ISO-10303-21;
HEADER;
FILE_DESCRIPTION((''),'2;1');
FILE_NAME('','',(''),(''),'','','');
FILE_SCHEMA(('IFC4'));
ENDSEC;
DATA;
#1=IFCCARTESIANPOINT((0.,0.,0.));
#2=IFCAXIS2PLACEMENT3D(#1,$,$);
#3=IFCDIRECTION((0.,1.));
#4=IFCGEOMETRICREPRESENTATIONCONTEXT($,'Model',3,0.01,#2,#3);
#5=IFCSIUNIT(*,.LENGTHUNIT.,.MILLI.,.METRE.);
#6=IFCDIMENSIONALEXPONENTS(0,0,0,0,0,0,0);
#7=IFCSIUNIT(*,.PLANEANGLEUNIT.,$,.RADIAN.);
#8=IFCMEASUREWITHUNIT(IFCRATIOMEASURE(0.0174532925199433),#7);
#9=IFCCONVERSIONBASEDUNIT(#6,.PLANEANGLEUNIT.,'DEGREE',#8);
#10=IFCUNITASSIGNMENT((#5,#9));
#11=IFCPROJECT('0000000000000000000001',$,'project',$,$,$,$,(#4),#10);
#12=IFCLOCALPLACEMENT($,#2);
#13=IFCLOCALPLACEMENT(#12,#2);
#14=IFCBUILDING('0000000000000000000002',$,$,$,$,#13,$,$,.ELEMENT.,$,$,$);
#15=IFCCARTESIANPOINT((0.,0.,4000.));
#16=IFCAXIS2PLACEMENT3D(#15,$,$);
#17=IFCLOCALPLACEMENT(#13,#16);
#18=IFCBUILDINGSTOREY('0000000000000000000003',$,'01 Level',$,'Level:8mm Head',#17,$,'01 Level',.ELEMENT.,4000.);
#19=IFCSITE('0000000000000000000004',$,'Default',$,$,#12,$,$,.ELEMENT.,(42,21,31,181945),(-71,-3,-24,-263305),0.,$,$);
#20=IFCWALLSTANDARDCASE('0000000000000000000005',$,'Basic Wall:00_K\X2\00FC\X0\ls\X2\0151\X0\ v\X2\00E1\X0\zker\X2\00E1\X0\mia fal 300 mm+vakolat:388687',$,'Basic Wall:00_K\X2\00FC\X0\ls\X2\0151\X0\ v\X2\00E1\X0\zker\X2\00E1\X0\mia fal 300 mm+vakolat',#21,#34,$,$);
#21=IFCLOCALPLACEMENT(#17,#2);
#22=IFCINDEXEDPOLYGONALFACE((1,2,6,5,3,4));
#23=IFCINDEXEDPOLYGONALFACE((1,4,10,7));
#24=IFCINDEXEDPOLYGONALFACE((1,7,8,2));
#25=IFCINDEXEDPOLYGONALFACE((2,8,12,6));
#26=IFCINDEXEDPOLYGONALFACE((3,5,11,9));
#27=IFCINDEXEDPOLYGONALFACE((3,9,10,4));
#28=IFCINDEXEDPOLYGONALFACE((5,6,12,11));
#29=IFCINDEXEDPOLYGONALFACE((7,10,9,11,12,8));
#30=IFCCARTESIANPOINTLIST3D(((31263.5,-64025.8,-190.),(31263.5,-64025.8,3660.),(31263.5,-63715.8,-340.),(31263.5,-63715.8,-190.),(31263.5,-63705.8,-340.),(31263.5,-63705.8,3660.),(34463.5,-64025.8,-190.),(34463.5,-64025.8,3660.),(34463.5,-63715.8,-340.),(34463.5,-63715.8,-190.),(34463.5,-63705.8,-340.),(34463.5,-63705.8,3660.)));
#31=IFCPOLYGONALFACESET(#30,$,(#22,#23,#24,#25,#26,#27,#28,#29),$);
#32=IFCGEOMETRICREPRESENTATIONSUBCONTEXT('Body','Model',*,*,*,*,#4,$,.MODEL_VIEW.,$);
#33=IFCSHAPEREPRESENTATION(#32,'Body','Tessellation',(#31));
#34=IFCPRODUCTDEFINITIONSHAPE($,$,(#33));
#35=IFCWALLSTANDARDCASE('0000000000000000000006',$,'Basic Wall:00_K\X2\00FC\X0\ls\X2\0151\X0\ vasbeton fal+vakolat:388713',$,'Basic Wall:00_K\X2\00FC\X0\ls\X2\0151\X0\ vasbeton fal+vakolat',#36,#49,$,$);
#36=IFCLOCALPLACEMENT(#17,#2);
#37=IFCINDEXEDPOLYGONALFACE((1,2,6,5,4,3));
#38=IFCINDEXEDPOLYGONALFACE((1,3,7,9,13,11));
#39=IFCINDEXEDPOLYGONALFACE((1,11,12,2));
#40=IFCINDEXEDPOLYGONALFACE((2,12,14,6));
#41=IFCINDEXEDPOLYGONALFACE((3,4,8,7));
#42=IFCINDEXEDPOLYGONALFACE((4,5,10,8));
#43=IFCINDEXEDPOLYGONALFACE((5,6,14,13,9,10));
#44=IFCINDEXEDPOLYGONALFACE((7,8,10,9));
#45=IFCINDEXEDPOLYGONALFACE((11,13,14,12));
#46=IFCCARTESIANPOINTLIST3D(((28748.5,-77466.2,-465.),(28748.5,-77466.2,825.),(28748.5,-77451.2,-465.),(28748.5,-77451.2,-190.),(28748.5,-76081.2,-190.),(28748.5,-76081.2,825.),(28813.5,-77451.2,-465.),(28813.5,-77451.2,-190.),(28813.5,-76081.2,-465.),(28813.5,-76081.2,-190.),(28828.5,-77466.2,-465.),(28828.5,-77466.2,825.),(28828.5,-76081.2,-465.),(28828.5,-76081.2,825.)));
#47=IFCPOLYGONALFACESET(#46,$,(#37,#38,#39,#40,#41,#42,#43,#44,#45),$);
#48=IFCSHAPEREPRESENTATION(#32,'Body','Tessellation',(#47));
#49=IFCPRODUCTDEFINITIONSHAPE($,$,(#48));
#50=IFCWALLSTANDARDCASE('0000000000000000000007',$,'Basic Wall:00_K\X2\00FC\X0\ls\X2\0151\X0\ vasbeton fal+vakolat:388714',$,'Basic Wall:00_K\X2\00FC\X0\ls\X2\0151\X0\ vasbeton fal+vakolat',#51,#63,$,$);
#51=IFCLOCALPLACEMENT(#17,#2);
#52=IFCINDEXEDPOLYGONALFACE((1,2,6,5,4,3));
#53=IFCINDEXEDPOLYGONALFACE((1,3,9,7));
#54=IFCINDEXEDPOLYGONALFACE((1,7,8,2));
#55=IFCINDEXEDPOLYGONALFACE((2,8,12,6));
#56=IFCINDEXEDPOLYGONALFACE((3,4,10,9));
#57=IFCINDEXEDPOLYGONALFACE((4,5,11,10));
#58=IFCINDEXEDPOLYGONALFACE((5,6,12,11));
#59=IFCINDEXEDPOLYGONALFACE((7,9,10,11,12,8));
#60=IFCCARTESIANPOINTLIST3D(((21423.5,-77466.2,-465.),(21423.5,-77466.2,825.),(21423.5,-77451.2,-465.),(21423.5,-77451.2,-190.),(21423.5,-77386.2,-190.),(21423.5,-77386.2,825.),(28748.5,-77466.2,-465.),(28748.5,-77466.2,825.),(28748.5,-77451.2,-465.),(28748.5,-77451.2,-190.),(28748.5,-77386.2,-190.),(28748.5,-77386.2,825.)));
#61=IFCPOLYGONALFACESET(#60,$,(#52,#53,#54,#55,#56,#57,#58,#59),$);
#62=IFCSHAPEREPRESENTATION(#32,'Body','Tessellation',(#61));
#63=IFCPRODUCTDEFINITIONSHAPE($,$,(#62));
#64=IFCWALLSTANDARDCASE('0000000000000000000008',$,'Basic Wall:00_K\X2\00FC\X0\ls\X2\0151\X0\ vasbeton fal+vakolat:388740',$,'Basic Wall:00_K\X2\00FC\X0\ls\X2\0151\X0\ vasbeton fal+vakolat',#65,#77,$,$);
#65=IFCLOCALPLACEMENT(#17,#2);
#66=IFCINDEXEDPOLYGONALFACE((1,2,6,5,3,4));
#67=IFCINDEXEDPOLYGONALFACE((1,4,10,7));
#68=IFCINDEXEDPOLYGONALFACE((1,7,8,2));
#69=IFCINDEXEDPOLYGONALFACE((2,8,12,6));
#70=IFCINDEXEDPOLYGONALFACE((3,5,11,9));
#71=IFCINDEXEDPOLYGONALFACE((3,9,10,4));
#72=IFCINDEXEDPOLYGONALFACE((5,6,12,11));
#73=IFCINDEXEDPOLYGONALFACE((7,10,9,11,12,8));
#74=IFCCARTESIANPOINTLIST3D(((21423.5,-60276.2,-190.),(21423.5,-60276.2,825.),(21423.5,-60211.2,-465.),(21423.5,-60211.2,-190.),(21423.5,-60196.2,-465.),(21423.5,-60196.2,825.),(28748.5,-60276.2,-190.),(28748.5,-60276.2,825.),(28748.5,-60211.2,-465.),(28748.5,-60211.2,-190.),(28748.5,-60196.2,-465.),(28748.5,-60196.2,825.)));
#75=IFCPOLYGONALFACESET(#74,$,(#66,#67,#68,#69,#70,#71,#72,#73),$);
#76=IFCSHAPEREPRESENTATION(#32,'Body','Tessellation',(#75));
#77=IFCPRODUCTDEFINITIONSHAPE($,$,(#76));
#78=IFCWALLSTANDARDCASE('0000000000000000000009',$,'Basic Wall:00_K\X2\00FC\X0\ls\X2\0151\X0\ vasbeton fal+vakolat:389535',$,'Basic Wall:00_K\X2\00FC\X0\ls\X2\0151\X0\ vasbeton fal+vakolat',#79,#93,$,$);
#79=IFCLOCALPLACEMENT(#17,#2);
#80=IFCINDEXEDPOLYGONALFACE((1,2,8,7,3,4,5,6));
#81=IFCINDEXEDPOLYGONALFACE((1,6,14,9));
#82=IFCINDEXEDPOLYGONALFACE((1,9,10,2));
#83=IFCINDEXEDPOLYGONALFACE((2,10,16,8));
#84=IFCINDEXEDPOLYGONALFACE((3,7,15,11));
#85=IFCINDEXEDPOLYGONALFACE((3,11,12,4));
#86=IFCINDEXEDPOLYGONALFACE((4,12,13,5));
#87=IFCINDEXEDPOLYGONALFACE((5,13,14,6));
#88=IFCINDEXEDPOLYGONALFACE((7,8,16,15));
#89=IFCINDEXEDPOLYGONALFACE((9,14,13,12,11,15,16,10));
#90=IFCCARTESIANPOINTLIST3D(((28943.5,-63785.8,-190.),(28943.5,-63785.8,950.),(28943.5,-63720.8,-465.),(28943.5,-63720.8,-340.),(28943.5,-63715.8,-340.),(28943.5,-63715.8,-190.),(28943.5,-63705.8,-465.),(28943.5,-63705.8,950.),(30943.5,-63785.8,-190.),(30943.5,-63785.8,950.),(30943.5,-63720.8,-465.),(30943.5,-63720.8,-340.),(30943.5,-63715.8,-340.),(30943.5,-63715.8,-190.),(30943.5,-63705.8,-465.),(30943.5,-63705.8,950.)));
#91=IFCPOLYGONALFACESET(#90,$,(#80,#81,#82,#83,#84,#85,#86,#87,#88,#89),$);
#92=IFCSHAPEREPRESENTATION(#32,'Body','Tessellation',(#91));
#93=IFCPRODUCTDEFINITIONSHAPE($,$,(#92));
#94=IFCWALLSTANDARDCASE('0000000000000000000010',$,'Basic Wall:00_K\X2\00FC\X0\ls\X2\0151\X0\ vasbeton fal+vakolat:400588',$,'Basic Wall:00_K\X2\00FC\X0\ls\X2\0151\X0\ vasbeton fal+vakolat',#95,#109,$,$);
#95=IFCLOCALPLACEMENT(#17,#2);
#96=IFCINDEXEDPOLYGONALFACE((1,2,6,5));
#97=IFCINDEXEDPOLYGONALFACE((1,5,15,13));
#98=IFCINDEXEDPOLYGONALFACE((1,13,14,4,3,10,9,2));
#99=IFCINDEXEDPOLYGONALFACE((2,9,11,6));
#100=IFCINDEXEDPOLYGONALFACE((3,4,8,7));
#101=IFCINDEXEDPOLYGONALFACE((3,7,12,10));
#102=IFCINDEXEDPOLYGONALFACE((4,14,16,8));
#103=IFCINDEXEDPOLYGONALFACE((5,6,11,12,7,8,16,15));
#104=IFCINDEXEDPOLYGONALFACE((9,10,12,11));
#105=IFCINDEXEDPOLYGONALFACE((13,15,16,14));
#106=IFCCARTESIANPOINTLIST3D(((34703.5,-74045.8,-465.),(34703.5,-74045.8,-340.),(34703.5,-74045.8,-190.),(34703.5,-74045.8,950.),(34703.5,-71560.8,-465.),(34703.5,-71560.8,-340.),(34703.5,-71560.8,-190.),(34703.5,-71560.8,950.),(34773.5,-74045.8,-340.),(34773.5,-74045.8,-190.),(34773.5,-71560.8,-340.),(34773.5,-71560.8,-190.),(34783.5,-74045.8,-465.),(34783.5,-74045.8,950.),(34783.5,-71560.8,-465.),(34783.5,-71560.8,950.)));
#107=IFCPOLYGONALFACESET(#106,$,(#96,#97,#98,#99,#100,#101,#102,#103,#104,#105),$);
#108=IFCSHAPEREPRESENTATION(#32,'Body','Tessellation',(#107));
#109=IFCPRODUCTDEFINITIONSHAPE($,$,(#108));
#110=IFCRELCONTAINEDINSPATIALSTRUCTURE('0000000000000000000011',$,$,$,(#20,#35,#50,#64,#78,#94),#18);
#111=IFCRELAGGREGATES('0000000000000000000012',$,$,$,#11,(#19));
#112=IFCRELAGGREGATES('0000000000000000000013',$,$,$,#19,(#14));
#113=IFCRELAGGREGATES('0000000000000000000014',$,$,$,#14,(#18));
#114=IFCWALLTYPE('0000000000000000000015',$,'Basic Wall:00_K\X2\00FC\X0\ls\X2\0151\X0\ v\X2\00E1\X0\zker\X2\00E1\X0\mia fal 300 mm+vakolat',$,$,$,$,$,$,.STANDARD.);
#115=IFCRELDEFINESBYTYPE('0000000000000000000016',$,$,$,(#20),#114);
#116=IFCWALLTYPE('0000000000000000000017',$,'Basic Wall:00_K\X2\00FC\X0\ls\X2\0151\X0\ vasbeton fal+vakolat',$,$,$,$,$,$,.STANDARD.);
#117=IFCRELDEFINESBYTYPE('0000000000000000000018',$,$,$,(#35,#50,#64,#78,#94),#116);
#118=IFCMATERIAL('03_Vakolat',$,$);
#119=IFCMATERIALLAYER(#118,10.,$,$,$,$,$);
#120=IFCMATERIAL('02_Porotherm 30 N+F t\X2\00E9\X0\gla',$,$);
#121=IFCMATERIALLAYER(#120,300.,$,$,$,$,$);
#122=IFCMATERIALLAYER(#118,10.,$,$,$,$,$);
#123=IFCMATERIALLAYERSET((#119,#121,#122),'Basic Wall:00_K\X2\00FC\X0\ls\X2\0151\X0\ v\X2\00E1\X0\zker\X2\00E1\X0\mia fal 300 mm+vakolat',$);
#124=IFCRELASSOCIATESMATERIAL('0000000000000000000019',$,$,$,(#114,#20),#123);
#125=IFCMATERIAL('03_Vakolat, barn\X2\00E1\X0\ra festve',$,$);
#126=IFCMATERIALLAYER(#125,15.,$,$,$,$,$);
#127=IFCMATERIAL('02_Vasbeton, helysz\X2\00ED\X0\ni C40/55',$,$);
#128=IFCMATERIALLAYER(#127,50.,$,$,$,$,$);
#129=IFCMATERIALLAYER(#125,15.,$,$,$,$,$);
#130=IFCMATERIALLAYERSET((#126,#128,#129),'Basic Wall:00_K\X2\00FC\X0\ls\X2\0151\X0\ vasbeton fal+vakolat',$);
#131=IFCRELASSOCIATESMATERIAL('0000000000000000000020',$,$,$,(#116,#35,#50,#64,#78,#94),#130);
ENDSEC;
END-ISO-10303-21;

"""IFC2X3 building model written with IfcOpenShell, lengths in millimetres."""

from ifc_helpers import new_model, entity, si_unit, converted_unit, direction, frame, frame_2d, origin, place, context, subcontext, project, spatial, polyline, rectangle, extrude, clip, bounded_halfspace, material, layer, layer_set, layer_usage, type_object, element, save


model = new_model("IFC2X3")

# Units and contexts
model_context = context("Model", 3, precision=0.01, world=origin(), true_north=direction((0.0, 1.0)))
body_context = subcontext(model_context, "Body", "Model", "MODEL_VIEW")
ifc_project = project(units=[si_unit("LENGTHUNIT", "METRE", prefix="MILLI"), converted_unit("PLANEANGLEUNIT", "DEGREE", entity("IfcRatioMeasure", 0.0174532925199433), si_unit("PLANEANGLEUNIT", "RADIAN"), dimensions=[0, 0, 0, 0, 0, 0, 0])], contexts=[model_context])

# Site, building, storey
site_placement = place(None, origin())
site = spatial("IfcSite", under=ifc_project, at=site_placement, Name="Default", CompositionType="ELEMENT", RefLatitude=(42, 21, 31, 181945), RefLongitude=(-71, -3, -24, -263305), RefElevation=0.0)
building_placement = place(site_placement, origin())
building = spatial("IfcBuilding", under=site, at=building_placement, CompositionType="ELEMENT")
storey_placement = place(building_placement, frame((0.0, 0.0, 4000.0)))
storey = spatial("IfcBuildingStorey", under=building, at=storey_placement, Name="01 Level", ObjectType="Level:8mm Head", LongName="01 Level", CompositionType="ELEMENT", Elevation=4000.0)

# Walls
ifc_material_1 = material(Name="03_Vakolat")
ifc_layer_1 = layer(ifc_material_1, 10.0)
ifc_material_2 = material(Name="02_Porotherm 30 N+F tégla")
ifc_layer_2 = layer(ifc_material_2, 300.0)
ifc_layer_3 = layer(ifc_material_1, 10.0)
ifc_layer_set_1 = layer_set([ifc_layer_1, ifc_layer_2, ifc_layer_3], Name="Basic Wall:00_Külső vázkerámia fal 300 mm+vakolat")
wall_type_1 = type_object("IfcWallType", Name="Basic Wall:00_Külső vázkerámia fal 300 mm+vakolat", PredefinedType="STANDARD", material=ifc_layer_set_1)
ifc_layer_usage_1 = layer_usage(ifc_layer_set_1, "AXIS2", "NEGATIVE", 160.0)
wall_1_placement = place(storey_placement, frame((31263.5, -63865.8, -340.0)))
element("IfcWallStandardCase", 1, at=wall_1_placement, inside=storey, type_object=wall_type_1, material=ifc_layer_usage_1, Name="Basic Wall:00_Külső vázkerámia fal 300 mm+vakolat:388687", ObjectType="Basic Wall:00_Külső vázkerámia fal 300 mm+vakolat", context=body_context, shape_type="Clipping", body=[
    clip(clip(extrude(rectangle(XDim=3200.0, YDim=320.0, at=frame_2d((1600.0, 0.0), x_axis=(-1.0, 0.0))), origin(), (0.0, 0.0, 1.0), 4000.0), bounded_halfspace(frame((0.0, 150.0, 150.0), z_axis=(0.0, 0.0, 1.0), x_axis=(0.0, 1.0, 0.0)), True, frame((0.0, 150.0, 150.0), z_axis=(0.0, 0.0, 1.0), x_axis=(0.0, 1.0, 0.0)), polyline([(0.0, 0.0), (-310.0, 0.0), (-310.0, -3200.0), (-5.0, -3200.0), (0.0, -3200.0), (0.0, 0.0)]))), bounded_halfspace(frame((3200.0, 150.0, 150.0), z_axis=(0.0, 1.0, 0.0), x_axis=(0.0, 0.0, 1.0)), True, frame((3200.0, 150.0, 150.0), z_axis=(0.0, 1.0, 0.0), x_axis=(0.0, 0.0, 1.0)), polyline([(0.0, 0.0), (-150.0, 0.0), (-150.0, -3200.0), (0.0, -3200.0), (0.0, 0.0)]))),
])
ifc_material_3 = material(Name="03_Vakolat, barnára festve")
ifc_layer_4 = layer(ifc_material_3, 15.0)
ifc_material_4 = material(Name="02_Vasbeton, helyszíni C40/55")
ifc_layer_5 = layer(ifc_material_4, 50.0)
ifc_layer_6 = layer(ifc_material_3, 15.0)
ifc_layer_set_2 = layer_set([ifc_layer_4, ifc_layer_5, ifc_layer_6], Name="Basic Wall:00_Külső vasbeton fal+vakolat")
ifc_layer_usage_2 = layer_usage(ifc_layer_set_2, "AXIS2", "NEGATIVE", 40.0)
wall_type_2 = type_object("IfcWallType", Name="Basic Wall:00_Külső vasbeton fal+vakolat", PredefinedType="STANDARD", material=ifc_layer_set_2)
wall_2_placement = place(storey_placement, frame((28788.5, -76081.2, -465.0), z_axis=(0.0, 0.0, 1.0), x_axis=(0.0, -1.0, 0.0)))
element("IfcWallStandardCase", 2, at=wall_2_placement, inside=storey, type_object=wall_type_2, material=ifc_layer_usage_2, Name="Basic Wall:00_Külső vasbeton fal+vakolat:388713", ObjectType="Basic Wall:00_Külső vasbeton fal+vakolat", context=body_context, shape_type="Clipping", body=[
    clip(clip(clip(extrude(rectangle(XDim=1385.0, YDim=80.0, at=frame_2d((692.5, 0.0), x_axis=(-1.0, 0.0))), origin(), (0.0, 0.0, 1.0), 1290.0), bounded_halfspace(frame((1370.0, 25.0, 275.0), z_axis=(0.0, 1.0, 0.0), x_axis=(0.0, 0.0, 1.0)), True, frame((1370.0, 25.0, 275.0), z_axis=(0.0, 1.0, 0.0), x_axis=(0.0, 0.0, 1.0)), polyline([(0.0, 0.0), (-150.0, 0.0), (-275.0, 0.0), (-275.0, -1370.0), (0.0, -1370.0), (0.0, 0.0)]))), bounded_halfspace(frame((1370.0, 25.0, 275.0), z_axis=(1.0, 0.0, 0.0), x_axis=(0.0, 0.0, 1.0)), True, frame((1370.0, 25.0, 275.0), z_axis=(1.0, 0.0, 0.0), x_axis=(0.0, 0.0, 1.0)), polyline([(0.0, 0.0), (0.0, 65.0), (-275.0, 65.0), (-275.0, 0.0), (-150.0, 0.0), (0.0, 0.0)]))), bounded_halfspace(frame((0.0, 25.0, 275.0), z_axis=(0.0, 0.0, 1.0), x_axis=(0.0, -1.0, 0.0)), True, frame((0.0, 25.0, 275.0), z_axis=(0.0, 0.0, 1.0), x_axis=(0.0, -1.0, 0.0)), polyline([(0.0, 0.0), (65.0, 0.0), (65.0, 1305.0), (65.0, 1370.0), (0.0, 1370.0), (0.0, 0.0)]))),
])
ifc_layer_usage_3 = layer_usage(ifc_layer_set_2, "AXIS2", "NEGATIVE", 40.0)
wall_3_placement = place(storey_placement, frame((28748.5, -77426.2, -465.0), z_axis=(0.0, 0.0, 1.0), x_axis=(-1.0, 0.0, 0.0)))
element("IfcWallStandardCase", 3, at=wall_3_placement, inside=storey, type_object=wall_type_2, material=ifc_layer_usage_3, Name="Basic Wall:00_Külső vasbeton fal+vakolat:388714", ObjectType="Basic Wall:00_Külső vasbeton fal+vakolat", context=body_context, shape_type="Clipping", body=[
    clip(clip(extrude(rectangle(XDim=7325.0, YDim=80.0, at=frame_2d((3662.5, 0.0), x_axis=(-1.0, 0.0))), origin(), (0.0, 0.0, 1.0), 1290.0), bounded_halfspace(frame((7325.0, -40.0, 275.0)), True, frame((7325.0, -40.0, 275.0)), polyline([(0.0, 0.0), (0.0, 65.0), (-7325.0, 65.0), (-7325.0, 0.0), (0.0, 0.0)]))), bounded_halfspace(frame((0.0, 25.0, 0.0), z_axis=(0.0, 1.0, 0.0), x_axis=(0.0, 0.0, 1.0)), True, frame((0.0, 25.0, 0.0), z_axis=(0.0, 1.0, 0.0), x_axis=(0.0, 0.0, 1.0)), polyline([(0.0, 0.0), (275.0, 0.0), (275.0, 7325.0), (0.0, 7325.0), (0.0, 0.0)]))),
])
ifc_layer_usage_4 = layer_usage(ifc_layer_set_2, "AXIS2", "POSITIVE", -40.0)
wall_4_placement = place(storey_placement, frame((28748.5, -60236.2, -465.0), z_axis=(0.0, 0.0, 1.0), x_axis=(-1.0, 0.0, 0.0)))
element("IfcWallStandardCase", 4, at=wall_4_placement, inside=storey, type_object=wall_type_2, material=ifc_layer_usage_4, Name="Basic Wall:00_Külső vasbeton fal+vakolat:388740", ObjectType="Basic Wall:00_Külső vasbeton fal+vakolat", context=body_context, shape_type="Clipping", body=[
    clip(clip(extrude(rectangle(XDim=7325.0, YDim=80.0, at=frame_2d((3662.5, 0.0), x_axis=(-1.0, 0.0))), origin(), (0.0, 0.0, 1.0), 1290.0), bounded_halfspace(frame((7325.0, -25.0, 275.0)), True, frame((7325.0, -25.0, 275.0)), polyline([(0.0, 0.0), (0.0, 65.0), (-7325.0, 65.0), (-7325.0, 0.0), (0.0, 0.0)]))), bounded_halfspace(frame((0.0, -25.0, 275.0), z_axis=(0.0, -1.0, 0.0), x_axis=(0.0, 0.0, 1.0)), True, frame((0.0, -25.0, 275.0), z_axis=(0.0, -1.0, 0.0), x_axis=(0.0, 0.0, 1.0)), polyline([(0.0, 0.0), (-275.0, 0.0), (-275.0, -7325.0), (0.0, -7325.0), (0.0, 0.0)]))),
])
ifc_layer_usage_5 = layer_usage(ifc_layer_set_2, "AXIS2", "NEGATIVE", 40.0)
wall_5_placement = place(storey_placement, frame((30943.5, -63745.8, -465.0), z_axis=(0.0, 0.0, 1.0), x_axis=(-1.0, 0.0, 0.0)))
element("IfcWallStandardCase", 5, at=wall_5_placement, inside=storey, type_object=wall_type_2, material=ifc_layer_usage_5, Name="Basic Wall:00_Külső vasbeton fal+vakolat:389535", ObjectType="Basic Wall:00_Külső vasbeton fal+vakolat", context=body_context, shape_type="Clipping", body=[
    clip(clip(extrude(rectangle(XDim=2000.0, YDim=80.0, at=frame_2d((1000.0, 0.0), x_axis=(-1.0, 0.0))), origin(), (0.0, 0.0, 1.0), 1415.0), bounded_halfspace(frame((0.0, -30.0, 275.0), z_axis=(0.0, -1.0, 0.0), x_axis=(0.0, 0.0, 1.0)), True, frame((0.0, -30.0, 275.0), z_axis=(0.0, -1.0, 0.0), x_axis=(0.0, 0.0, 1.0)), polyline([(0.0, 0.0), (-150.0, 0.0), (-150.0, -2000.0), (0.0, -2000.0), (0.0, 0.0)]))), bounded_halfspace(frame((2000.0, -25.0, 0.0), z_axis=(0.0, -1.0, 0.0), x_axis=(0.0, 0.0, 1.0)), True, frame((2000.0, -25.0, 0.0), z_axis=(0.0, -1.0, 0.0), x_axis=(0.0, 0.0, 1.0)), polyline([(0.0, 0.0), (125.0, 0.0), (125.0, 2000.0), (0.0, 2000.0), (0.0, 0.0)]))),
])
ifc_layer_usage_6 = layer_usage(ifc_layer_set_2, "AXIS2", "NEGATIVE", 40.0)
wall_6_placement = place(storey_placement, frame((34743.5, -71560.8, -465.0), z_axis=(0.0, 0.0, 1.0), x_axis=(0.0, -1.0, 0.0)))
element("IfcWallStandardCase", 6, at=wall_6_placement, inside=storey, type_object=wall_type_2, material=ifc_layer_usage_6, Name="Basic Wall:00_Külső vasbeton fal+vakolat:400588", ObjectType="Basic Wall:00_Külső vasbeton fal+vakolat", context=body_context, shape_type="Clipping", body=[
    clip(extrude(rectangle(XDim=2485.0, YDim=80.0, at=frame_2d((1242.5, 0.0), x_axis=(-1.0, 0.0))), origin(), (0.0, 0.0, 1.0), 1415.0), bounded_halfspace(frame((0.0, 30.0, 125.0), z_axis=(0.0, 1.0, 0.0), x_axis=(0.0, 0.0, 1.0)), True, frame((0.0, 30.0, 125.0), z_axis=(0.0, 1.0, 0.0), x_axis=(0.0, 0.0, 1.0)), polyline([(0.0, 0.0), (150.0, 0.0), (150.0, 2485.0), (0.0, 2485.0), (0.0, 0.0)]))),
])

save(model, "model.ifc")
